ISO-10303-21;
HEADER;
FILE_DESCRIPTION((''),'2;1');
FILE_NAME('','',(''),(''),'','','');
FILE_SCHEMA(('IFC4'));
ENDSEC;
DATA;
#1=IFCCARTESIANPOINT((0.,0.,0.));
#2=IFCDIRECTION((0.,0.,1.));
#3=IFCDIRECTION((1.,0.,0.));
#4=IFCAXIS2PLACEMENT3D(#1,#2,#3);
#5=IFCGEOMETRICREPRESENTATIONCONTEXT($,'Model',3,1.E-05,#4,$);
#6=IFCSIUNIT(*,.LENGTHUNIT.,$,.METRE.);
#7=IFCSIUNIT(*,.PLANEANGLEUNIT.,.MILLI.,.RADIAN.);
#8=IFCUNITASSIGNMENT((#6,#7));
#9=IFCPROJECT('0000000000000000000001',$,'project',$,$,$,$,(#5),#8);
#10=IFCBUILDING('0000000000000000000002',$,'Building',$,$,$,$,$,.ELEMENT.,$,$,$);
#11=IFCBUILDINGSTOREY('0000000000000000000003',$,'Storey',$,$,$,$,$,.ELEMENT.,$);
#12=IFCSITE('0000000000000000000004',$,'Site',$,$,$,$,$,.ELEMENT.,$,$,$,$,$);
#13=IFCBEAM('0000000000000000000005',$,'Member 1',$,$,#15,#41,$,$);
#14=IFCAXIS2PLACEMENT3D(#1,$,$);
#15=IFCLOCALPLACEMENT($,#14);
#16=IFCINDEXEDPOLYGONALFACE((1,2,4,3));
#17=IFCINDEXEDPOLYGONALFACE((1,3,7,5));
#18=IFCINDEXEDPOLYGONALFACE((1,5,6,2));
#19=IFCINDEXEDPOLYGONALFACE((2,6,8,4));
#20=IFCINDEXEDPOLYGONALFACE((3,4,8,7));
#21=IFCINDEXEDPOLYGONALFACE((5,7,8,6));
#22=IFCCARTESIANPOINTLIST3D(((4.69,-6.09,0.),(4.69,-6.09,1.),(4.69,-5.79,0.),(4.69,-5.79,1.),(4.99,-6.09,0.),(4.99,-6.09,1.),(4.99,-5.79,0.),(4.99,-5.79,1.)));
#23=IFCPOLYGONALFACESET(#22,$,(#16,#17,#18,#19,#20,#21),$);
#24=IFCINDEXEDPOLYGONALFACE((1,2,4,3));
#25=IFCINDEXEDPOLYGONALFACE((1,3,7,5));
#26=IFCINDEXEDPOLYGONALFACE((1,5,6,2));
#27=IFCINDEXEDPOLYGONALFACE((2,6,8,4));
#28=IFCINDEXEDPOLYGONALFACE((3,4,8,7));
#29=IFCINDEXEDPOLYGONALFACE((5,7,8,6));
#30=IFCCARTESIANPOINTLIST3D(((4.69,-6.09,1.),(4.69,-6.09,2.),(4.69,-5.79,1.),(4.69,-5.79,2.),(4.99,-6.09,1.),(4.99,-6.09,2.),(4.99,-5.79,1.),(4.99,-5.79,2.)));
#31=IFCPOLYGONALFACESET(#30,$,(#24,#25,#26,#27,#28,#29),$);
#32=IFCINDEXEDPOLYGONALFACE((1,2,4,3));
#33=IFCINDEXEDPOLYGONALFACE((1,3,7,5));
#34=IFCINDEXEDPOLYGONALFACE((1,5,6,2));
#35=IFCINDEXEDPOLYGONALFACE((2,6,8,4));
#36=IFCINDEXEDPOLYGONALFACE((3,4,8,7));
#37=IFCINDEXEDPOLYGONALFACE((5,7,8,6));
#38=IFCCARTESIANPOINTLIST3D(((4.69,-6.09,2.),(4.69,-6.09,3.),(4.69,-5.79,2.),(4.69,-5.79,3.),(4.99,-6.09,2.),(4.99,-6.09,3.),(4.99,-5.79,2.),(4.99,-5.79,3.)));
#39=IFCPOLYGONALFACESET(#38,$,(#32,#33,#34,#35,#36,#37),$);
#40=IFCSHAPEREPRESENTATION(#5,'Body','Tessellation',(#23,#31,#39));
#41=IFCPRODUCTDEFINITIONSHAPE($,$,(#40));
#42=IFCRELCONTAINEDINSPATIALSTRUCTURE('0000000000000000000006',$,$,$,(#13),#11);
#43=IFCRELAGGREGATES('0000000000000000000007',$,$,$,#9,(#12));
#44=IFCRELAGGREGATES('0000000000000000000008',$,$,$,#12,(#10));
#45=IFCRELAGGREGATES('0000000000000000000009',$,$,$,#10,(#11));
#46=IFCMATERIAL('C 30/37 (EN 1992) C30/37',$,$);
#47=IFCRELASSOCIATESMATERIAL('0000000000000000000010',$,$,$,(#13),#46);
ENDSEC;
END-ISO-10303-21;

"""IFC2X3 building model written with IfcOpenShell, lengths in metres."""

from ifc_helpers import new_model, si_unit, frame, frame_2d, origin_with_axes, place, context, project, spatial, rectangle, extrude, material, element, save


model = new_model("IFC2X3")

# Units and contexts
model_context = context("Model", 3, precision=1e-05, world=origin_with_axes())
ifc_project = project(units=[si_unit("LENGTHUNIT", "METRE"), si_unit("PLANEANGLEUNIT", "RADIAN", prefix="MILLI")], contexts=[model_context])

# Site, building, storey
site = spatial("IfcSite", under=ifc_project, Name="Site", CompositionType="ELEMENT")
building = spatial("IfcBuilding", under=site, Name="Building", CompositionType="ELEMENT")
storey = spatial("IfcBuildingStorey", under=building, Name="Storey", CompositionType="ELEMENT")

# Beam
ifc_material = material(Name="C 30/37 (EN 1992) C30/37")
placement = place(None, frame((0.0, 0.0, 0.0), z_axis=(0.0, 0.0, -1.0), x_axis=(1.0, 0.0, 0.0)))
beam_placement = place(placement, frame((4.84, 5.94, 0.0), z_axis=(1.0, 0.0, 0.0), x_axis=(0.0, -1.0, 0.0)))
element("IfcBeam", 1, at=beam_placement, inside=storey, material=ifc_material, Name="Member 1", context=model_context, shape_type="SweptSolid", body=[
    extrude(rectangle(XDim=0.3, YDim=0.3, at=frame_2d((0.0, 0.0), x_axis=(-1.0, 0.0))), frame((0.0, 0.0, 0.0), z_axis=(0.0, 1.0, 0.0), x_axis=(1.0, 0.0, 0.0)), (0.0, 0.0, 1.0), 1.0),
    extrude(rectangle(XDim=0.3, YDim=0.3, at=frame_2d((0.0, 0.0), x_axis=(-1.0, 0.0))), frame((0.0, 1.0, 0.0), z_axis=(0.0, 1.0, 0.0), x_axis=(1.0, 0.0, 0.0)), (0.0, 0.0, 1.0), 1.0),
    extrude(rectangle(XDim=0.3, YDim=0.3, at=frame_2d((0.0, 0.0), x_axis=(-1.0, 0.0))), frame((0.0, 2.0, 0.0), z_axis=(0.0, 1.0, 0.0), x_axis=(1.0, 0.0, 0.0)), (0.0, 0.0, 1.0), 1.0),
])

save(model, "model.ifc")
